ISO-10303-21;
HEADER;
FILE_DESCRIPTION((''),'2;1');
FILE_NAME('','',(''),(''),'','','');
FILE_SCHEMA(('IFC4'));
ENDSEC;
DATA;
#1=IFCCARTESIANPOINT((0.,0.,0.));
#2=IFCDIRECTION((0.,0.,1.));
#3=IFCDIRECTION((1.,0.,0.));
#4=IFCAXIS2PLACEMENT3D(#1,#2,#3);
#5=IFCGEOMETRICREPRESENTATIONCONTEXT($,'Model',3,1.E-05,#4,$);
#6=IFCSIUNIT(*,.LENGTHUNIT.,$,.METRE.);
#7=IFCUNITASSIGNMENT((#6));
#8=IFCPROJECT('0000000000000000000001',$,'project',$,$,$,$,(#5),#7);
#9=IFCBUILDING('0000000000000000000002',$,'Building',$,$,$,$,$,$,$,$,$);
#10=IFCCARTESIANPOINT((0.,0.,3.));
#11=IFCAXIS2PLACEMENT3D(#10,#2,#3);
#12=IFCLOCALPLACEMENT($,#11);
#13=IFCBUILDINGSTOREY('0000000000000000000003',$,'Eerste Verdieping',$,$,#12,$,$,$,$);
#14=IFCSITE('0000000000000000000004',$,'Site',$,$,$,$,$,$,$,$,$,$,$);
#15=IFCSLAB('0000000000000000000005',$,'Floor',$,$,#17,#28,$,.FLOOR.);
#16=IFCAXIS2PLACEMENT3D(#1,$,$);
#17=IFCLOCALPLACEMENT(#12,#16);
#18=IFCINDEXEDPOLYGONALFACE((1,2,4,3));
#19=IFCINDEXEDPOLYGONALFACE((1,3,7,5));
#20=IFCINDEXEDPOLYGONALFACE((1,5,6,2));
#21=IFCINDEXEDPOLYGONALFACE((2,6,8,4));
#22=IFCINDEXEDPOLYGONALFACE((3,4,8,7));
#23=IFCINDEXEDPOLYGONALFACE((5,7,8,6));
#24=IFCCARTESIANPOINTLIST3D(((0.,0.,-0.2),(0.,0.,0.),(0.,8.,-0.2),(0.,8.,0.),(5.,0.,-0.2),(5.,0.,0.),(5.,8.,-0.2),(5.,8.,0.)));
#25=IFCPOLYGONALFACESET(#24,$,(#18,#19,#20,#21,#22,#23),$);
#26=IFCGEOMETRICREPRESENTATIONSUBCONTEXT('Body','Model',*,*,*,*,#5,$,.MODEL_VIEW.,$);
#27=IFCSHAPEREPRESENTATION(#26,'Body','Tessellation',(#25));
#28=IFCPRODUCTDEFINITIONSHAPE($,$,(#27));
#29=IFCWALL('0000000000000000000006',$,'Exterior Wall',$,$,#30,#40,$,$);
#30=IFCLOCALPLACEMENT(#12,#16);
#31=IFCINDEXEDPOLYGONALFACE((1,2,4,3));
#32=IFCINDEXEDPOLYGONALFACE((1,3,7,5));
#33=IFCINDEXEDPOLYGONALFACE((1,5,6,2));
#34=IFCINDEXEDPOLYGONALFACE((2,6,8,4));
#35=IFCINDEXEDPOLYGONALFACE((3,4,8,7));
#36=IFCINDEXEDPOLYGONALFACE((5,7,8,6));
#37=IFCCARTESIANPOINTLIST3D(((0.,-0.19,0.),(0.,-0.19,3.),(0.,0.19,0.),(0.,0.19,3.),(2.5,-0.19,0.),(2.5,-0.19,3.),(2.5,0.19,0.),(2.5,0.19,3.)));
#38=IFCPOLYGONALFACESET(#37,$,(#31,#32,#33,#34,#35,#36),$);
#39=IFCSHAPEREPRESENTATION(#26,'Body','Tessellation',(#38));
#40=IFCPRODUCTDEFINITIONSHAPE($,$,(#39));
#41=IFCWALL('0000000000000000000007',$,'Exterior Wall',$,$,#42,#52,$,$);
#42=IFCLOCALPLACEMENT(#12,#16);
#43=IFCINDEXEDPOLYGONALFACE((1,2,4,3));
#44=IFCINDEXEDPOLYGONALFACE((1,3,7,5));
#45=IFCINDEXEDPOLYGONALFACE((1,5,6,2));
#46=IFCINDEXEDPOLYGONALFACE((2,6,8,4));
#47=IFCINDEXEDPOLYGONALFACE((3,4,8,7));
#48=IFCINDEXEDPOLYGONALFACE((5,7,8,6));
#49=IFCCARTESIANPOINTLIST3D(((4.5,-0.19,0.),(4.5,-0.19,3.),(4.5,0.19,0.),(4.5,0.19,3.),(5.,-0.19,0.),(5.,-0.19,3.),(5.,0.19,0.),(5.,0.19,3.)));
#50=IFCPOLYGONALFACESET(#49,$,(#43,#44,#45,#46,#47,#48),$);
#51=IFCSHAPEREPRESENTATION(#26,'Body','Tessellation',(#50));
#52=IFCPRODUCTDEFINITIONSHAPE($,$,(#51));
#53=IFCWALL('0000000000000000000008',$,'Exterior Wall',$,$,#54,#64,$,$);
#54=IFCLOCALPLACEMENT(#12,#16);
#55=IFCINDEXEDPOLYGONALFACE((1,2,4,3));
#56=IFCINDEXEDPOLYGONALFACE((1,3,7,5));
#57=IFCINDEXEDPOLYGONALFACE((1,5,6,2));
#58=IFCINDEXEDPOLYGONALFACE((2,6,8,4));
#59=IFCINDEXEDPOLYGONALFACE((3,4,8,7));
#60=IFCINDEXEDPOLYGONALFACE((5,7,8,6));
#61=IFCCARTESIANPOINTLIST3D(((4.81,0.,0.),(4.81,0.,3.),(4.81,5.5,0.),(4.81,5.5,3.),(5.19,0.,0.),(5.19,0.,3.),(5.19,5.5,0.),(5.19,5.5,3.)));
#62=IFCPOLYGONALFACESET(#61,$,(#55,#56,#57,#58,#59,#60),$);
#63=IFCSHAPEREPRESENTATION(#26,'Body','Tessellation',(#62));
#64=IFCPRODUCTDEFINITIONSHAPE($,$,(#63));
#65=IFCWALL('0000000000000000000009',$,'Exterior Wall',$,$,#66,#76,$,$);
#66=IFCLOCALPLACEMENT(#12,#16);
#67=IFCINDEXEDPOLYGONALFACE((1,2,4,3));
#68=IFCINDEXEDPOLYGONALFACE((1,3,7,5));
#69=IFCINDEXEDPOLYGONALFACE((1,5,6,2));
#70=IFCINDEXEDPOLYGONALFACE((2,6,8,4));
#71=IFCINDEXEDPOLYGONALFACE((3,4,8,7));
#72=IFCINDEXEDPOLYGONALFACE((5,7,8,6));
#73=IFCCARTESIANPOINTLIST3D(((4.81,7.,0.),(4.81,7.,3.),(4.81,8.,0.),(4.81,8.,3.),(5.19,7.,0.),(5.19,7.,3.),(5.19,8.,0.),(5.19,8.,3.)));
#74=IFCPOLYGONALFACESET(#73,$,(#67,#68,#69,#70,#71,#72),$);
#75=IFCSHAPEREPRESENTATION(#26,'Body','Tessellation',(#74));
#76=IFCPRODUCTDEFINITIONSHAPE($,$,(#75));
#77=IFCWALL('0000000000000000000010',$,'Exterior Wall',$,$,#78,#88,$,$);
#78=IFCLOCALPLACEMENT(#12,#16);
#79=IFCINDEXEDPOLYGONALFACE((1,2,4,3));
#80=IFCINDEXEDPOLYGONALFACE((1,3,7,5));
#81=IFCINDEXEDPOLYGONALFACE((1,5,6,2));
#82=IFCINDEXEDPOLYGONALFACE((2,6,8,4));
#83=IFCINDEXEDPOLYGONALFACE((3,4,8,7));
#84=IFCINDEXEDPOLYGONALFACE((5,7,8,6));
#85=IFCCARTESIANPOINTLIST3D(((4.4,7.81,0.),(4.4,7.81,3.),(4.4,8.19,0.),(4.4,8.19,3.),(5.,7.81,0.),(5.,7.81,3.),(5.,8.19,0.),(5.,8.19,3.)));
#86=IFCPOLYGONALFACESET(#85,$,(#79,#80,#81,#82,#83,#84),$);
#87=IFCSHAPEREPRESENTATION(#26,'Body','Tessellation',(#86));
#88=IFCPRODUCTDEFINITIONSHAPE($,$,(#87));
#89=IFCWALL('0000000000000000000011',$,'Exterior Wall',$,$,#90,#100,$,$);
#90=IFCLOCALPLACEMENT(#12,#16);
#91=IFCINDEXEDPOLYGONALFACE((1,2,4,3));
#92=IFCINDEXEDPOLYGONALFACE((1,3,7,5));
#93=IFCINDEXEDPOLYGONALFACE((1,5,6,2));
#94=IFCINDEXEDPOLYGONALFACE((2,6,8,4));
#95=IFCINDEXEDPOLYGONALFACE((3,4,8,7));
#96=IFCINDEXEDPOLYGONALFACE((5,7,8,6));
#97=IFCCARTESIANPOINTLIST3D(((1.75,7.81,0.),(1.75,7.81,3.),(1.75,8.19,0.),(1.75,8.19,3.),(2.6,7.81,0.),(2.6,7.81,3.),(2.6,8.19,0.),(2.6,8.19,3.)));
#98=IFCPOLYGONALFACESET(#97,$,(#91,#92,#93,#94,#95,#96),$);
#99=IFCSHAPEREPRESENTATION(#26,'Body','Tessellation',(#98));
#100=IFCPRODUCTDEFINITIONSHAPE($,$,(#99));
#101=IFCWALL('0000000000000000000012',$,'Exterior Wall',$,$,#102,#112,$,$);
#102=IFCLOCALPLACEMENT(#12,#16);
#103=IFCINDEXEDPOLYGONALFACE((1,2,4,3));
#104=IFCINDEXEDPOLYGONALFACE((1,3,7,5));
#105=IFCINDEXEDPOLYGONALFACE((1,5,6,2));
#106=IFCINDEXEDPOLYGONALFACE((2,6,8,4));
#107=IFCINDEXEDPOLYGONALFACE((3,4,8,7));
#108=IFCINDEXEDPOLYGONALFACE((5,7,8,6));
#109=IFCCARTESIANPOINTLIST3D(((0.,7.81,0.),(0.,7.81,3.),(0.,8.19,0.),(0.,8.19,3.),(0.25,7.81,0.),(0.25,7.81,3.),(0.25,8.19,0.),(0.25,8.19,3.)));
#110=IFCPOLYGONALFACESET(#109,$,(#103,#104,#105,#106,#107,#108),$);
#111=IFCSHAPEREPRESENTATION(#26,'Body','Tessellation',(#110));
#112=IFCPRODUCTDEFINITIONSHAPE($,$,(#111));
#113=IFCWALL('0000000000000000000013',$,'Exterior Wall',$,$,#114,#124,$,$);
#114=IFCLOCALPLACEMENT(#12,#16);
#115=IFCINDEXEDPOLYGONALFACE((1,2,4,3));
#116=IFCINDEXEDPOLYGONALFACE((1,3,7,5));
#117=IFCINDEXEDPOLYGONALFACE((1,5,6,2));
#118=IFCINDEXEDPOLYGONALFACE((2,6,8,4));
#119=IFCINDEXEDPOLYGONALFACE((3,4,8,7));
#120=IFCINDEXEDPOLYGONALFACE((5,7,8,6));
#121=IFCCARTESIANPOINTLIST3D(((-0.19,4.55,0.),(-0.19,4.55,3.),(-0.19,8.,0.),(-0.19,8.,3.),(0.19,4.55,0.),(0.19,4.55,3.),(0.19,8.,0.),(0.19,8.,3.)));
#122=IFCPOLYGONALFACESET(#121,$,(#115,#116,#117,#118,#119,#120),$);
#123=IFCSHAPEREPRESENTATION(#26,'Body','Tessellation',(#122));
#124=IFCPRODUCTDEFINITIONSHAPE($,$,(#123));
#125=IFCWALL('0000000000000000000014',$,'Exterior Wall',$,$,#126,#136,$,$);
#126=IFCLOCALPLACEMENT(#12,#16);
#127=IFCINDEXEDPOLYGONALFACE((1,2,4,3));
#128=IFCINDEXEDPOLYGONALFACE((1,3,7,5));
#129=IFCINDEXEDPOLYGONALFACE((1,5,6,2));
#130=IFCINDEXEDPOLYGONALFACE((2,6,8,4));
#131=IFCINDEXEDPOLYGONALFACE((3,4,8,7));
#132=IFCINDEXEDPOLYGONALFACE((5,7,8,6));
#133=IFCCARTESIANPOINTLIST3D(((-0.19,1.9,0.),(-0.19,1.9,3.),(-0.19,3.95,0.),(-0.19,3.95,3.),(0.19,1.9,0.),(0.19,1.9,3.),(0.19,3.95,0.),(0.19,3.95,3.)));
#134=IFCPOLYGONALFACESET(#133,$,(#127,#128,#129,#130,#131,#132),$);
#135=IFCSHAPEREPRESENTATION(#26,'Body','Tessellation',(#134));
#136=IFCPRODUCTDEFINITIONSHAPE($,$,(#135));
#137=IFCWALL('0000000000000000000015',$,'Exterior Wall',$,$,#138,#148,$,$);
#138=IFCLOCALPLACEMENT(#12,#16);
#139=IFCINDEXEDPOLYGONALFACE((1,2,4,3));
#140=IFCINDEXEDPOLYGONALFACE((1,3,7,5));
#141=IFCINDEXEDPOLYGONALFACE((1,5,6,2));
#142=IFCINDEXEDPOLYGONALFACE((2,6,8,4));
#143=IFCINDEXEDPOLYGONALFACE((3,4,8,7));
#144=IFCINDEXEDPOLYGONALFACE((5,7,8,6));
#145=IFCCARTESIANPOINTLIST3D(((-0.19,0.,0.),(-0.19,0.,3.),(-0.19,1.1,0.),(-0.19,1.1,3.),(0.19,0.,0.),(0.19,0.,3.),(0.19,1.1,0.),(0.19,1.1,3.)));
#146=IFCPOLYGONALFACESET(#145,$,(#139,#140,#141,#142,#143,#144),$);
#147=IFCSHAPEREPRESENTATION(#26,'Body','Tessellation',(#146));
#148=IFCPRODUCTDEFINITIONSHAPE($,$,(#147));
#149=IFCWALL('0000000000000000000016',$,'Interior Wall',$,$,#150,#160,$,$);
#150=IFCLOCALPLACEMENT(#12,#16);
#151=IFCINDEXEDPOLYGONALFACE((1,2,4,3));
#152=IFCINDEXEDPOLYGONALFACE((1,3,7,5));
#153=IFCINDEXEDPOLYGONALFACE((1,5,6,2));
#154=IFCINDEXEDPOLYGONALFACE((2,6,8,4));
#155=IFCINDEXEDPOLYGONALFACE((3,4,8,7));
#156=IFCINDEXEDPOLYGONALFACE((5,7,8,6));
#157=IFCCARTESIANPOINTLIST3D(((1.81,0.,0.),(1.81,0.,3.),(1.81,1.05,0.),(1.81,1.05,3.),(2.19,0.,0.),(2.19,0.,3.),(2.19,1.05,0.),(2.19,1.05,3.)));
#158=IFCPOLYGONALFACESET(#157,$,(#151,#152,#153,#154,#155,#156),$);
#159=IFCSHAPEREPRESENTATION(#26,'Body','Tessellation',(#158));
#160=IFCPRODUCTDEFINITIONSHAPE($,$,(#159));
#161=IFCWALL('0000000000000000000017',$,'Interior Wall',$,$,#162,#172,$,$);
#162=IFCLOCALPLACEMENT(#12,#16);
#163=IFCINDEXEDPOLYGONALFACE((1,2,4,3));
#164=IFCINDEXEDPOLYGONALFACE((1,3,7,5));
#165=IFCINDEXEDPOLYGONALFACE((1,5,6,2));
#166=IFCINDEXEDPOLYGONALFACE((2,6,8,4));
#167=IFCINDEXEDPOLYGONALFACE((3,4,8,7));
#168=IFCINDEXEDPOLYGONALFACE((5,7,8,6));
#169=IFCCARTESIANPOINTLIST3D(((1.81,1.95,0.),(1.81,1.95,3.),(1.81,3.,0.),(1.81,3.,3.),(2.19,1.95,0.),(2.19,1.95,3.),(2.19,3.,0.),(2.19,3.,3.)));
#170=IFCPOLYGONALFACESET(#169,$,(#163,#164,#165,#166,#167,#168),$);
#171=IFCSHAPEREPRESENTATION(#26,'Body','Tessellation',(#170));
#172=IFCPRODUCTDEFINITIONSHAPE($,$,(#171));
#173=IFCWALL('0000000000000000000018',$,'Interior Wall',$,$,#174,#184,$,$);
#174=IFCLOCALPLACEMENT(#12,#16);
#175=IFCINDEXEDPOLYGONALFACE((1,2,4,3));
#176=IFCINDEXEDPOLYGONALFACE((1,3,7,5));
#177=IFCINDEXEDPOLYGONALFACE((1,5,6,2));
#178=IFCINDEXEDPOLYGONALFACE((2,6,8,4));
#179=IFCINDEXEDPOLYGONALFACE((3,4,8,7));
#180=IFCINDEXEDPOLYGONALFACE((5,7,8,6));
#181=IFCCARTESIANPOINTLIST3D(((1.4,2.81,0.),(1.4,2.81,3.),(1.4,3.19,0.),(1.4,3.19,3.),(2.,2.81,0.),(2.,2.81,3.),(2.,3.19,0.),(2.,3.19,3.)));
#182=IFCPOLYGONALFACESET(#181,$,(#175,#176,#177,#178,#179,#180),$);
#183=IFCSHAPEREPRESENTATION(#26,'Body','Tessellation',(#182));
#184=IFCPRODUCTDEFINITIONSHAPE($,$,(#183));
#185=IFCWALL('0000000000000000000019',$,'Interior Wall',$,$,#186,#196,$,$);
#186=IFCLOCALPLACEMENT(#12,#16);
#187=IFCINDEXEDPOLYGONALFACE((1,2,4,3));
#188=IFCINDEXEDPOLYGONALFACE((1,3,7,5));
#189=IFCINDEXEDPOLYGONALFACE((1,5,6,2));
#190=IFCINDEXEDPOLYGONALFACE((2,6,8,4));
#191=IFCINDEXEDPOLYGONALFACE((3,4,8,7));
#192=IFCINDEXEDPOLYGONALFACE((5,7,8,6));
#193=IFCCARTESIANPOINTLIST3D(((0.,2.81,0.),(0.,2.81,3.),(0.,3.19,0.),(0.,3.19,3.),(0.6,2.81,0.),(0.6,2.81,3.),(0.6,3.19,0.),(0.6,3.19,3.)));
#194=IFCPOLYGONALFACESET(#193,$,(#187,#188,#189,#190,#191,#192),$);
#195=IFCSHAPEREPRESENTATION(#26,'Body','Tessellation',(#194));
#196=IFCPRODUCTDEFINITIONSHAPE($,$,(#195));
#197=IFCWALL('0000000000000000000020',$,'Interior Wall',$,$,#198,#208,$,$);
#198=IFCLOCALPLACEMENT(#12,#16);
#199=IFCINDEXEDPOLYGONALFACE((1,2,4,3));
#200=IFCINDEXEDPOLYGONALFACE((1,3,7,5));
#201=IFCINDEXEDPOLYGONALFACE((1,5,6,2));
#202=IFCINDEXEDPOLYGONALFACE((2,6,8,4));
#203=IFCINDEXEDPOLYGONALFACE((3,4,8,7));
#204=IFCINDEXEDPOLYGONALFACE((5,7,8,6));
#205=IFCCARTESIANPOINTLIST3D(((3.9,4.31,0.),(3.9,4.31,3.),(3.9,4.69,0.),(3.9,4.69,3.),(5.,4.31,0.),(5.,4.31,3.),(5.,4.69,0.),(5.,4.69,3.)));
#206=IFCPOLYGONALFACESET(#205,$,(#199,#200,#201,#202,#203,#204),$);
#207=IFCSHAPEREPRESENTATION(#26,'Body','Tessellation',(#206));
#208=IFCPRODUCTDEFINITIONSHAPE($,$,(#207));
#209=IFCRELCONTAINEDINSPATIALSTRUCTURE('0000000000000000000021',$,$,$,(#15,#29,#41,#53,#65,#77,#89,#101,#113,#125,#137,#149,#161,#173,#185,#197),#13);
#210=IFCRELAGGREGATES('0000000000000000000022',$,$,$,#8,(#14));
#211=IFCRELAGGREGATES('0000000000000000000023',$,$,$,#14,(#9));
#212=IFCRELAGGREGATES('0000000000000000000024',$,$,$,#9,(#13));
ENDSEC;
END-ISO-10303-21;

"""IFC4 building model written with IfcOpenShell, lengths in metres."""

from ifc_helpers import new_model, si_unit, frame, origin_with_axes, place, context, subcontext, project, spatial, indexed_curve, outline, extrude, element, save


model = new_model("IFC4")

# Units and contexts
model_context = context("Model", 3, precision=1e-05, world=origin_with_axes())
body_context = subcontext(model_context, "Body", "Model", "MODEL_VIEW")
ifc_project = project(units=[si_unit("LENGTHUNIT", "METRE")], contexts=[model_context])

# Site, building, storey
site = spatial("IfcSite", under=ifc_project, Name="Site")
building = spatial("IfcBuilding", under=site, Name="Building")
storey_placement = place(None, frame((0.0, 0.0, 3.0), z_axis=(0.0, 0.0, 1.0), x_axis=(1.0, 0.0, 0.0)))
storey = spatial("IfcBuildingStorey", under=building, at=storey_placement, Name="Eerste Verdieping")

# Slab
slab_placement = place(storey_placement, frame((0.0, 0.0, -0.2), z_axis=(0.0, 0.0, 1.0), x_axis=(1.0, 0.0, 0.0)))
element("IfcSlab", 1, at=slab_placement, inside=storey, Name="Floor", PredefinedType="FLOOR", context=body_context, shape_type="SweptSolid", body=[
    extrude(outline(indexed_curve([(0.0, 0.0), (5.0, 0.0), (5.0, 8.0), (0.0, 8.0)])), None, (0.0, 0.0, 1.0), 0.2),
])

# Walls
wall_1_placement = place(storey_placement, origin_with_axes())
element("IfcWall", 2, at=wall_1_placement, inside=storey, Name="Exterior Wall", context=body_context, shape_type="SweptSolid", body=[
    extrude(outline(indexed_curve([(0.0, 0.0), (0.0, 0.38), (2.5, 0.38), (2.5, 0.0), (0.0, 0.0)], self_intersect=False)), frame((0.0, -0.19, 0.0), z_axis=(0.0, 0.0, 1.0), x_axis=(1.0, 0.0, 0.0)), (0.0, 0.0, 1.0), 3.0),
])
wall_2_placement = place(storey_placement, frame((4.5, 0.0, 0.0), z_axis=(0.0, 0.0, 1.0), x_axis=(1.0, 0.0, 0.0)))
element("IfcWall", 3, at=wall_2_placement, inside=storey, Name="Exterior Wall", context=body_context, shape_type="SweptSolid", body=[
    extrude(outline(indexed_curve([(0.0, 0.0), (0.0, 0.38), (0.5, 0.38), (0.5, 0.0), (0.0, 0.0)], self_intersect=False)), frame((0.0, -0.19, 0.0), z_axis=(0.0, 0.0, 1.0), x_axis=(1.0, 0.0, 0.0)), (0.0, 0.0, 1.0), 3.0),
])
wall_3_placement = place(storey_placement, frame((5.0, 0.0, 0.0), z_axis=(0.0, 0.0, 1.0), x_axis=(0.0, 1.0, 0.0)))
element("IfcWall", 4, at=wall_3_placement, inside=storey, Name="Exterior Wall", context=body_context, shape_type="SweptSolid", body=[
    extrude(outline(indexed_curve([(0.0, 0.0), (0.0, 0.38), (5.5, 0.38), (5.5, 0.0), (0.0, 0.0)], self_intersect=False)), frame((0.0, -0.19, 0.0), z_axis=(0.0, 0.0, 1.0), x_axis=(1.0, 0.0, 0.0)), (0.0, 0.0, 1.0), 3.0),
])
wall_4_placement = place(storey_placement, frame((5.0, 7.0, 0.0), z_axis=(0.0, 0.0, 1.0), x_axis=(0.0, 1.0, 0.0)))
element("IfcWall", 5, at=wall_4_placement, inside=storey, Name="Exterior Wall", context=body_context, shape_type="SweptSolid", body=[
    extrude(outline(indexed_curve([(0.0, 0.0), (0.0, 0.38), (1.0, 0.38), (1.0, 0.0), (0.0, 0.0)], self_intersect=False)), frame((0.0, -0.19, 0.0), z_axis=(0.0, 0.0, 1.0), x_axis=(1.0, 0.0, 0.0)), (0.0, 0.0, 1.0), 3.0),
])
wall_5_placement = place(storey_placement, frame((5.0, 8.0, 0.0), z_axis=(0.0, 0.0, 1.0), x_axis=(-1.0, 0.0, 0.0)))
element("IfcWall", 6, at=wall_5_placement, inside=storey, Name="Exterior Wall", context=body_context, shape_type="SweptSolid", body=[
    extrude(outline(indexed_curve([(0.0, 0.0), (0.0, 0.38), (0.6, 0.38), (0.6, 0.0), (0.0, 0.0)], self_intersect=False)), frame((0.0, -0.19, 0.0), z_axis=(0.0, 0.0, 1.0), x_axis=(1.0, 0.0, 0.0)), (0.0, 0.0, 1.0), 3.0),
])
wall_6_placement = place(storey_placement, frame((2.6, 8.0, 0.0), z_axis=(0.0, 0.0, 1.0), x_axis=(-1.0, 0.0, 0.0)))
element("IfcWall", 7, at=wall_6_placement, inside=storey, Name="Exterior Wall", context=body_context, shape_type="SweptSolid", body=[
    extrude(outline(indexed_curve([(0.0, 0.0), (0.0, 0.38), (0.85, 0.38), (0.85, 0.0), (0.0, 0.0)], self_intersect=False)), frame((0.0, -0.19, 0.0), z_axis=(0.0, 0.0, 1.0), x_axis=(1.0, 0.0, 0.0)), (0.0, 0.0, 1.0), 3.0),
])
wall_7_placement = place(storey_placement, frame((0.25, 8.0, 0.0), z_axis=(0.0, 0.0, 1.0), x_axis=(-1.0, 0.0, 0.0)))
element("IfcWall", 8, at=wall_7_placement, inside=storey, Name="Exterior Wall", context=body_context, shape_type="SweptSolid", body=[
    extrude(outline(indexed_curve([(0.0, 0.0), (0.0, 0.38), (0.25, 0.38), (0.25, 0.0), (0.0, 0.0)], self_intersect=False)), frame((0.0, -0.19, 0.0), z_axis=(0.0, 0.0, 1.0), x_axis=(1.0, 0.0, 0.0)), (0.0, 0.0, 1.0), 3.0),
])
wall_8_placement = place(storey_placement, frame((0.0, 8.0, 0.0), z_axis=(0.0, 0.0, 1.0), x_axis=(0.0, -1.0, 0.0)))
element("IfcWall", 9, at=wall_8_placement, inside=storey, Name="Exterior Wall", context=body_context, shape_type="SweptSolid", body=[
    extrude(outline(indexed_curve([(0.0, 0.0), (0.0, 0.38), (3.45, 0.38), (3.45, 0.0), (0.0, 0.0)], self_intersect=False)), frame((0.0, -0.19, 0.0), z_axis=(0.0, 0.0, 1.0), x_axis=(1.0, 0.0, 0.0)), (0.0, 0.0, 1.0), 3.0),
])
wall_9_placement = place(storey_placement, frame((0.0, 3.95, 0.0), z_axis=(0.0, 0.0, 1.0), x_axis=(0.0, -1.0, 0.0)))
element("IfcWall", 10, at=wall_9_placement, inside=storey, Name="Exterior Wall", context=body_context, shape_type="SweptSolid", body=[
    extrude(outline(indexed_curve([(0.0, 0.0), (0.0, 0.38), (2.05, 0.38), (2.05, 0.0), (0.0, 0.0)], self_intersect=False)), frame((0.0, -0.19, 0.0), z_axis=(0.0, 0.0, 1.0), x_axis=(1.0, 0.0, 0.0)), (0.0, 0.0, 1.0), 3.0),
])
wall_10_placement = place(storey_placement, frame((0.0, 1.1, 0.0), z_axis=(0.0, 0.0, 1.0), x_axis=(0.0, -1.0, 0.0)))
element("IfcWall", 11, at=wall_10_placement, inside=storey, Name="Exterior Wall", context=body_context, shape_type="SweptSolid", body=[
    extrude(outline(indexed_curve([(0.0, 0.0), (0.0, 0.38), (1.1, 0.38), (1.1, 0.0), (0.0, 0.0)], self_intersect=False)), frame((0.0, -0.19, 0.0), z_axis=(0.0, 0.0, 1.0), x_axis=(1.0, 0.0, 0.0)), (0.0, 0.0, 1.0), 3.0),
])
for number, where, z_axis, x_axis, name in (
    (12, (2.0, 0.0, 0.0), (0.0, 0.0, 1.0), (0.0, 1.0, 0.0), "Interior Wall"),
    (13, (2.0, 1.95, 0.0), (0.0, 0.0, 1.0), (0.0, 1.0, 0.0), "Interior Wall"),
):
    element("IfcWall", number, at=place(storey_placement, frame(where, z_axis=z_axis, x_axis=x_axis)), inside=storey, Name=name, context=body_context, shape_type="SweptSolid", body=[
        extrude(outline(indexed_curve([(0.0, 0.0), (0.0, 0.38), (1.05, 0.38), (1.05, 0.0), (0.0, 0.0)], self_intersect=False)), frame((0.0, -0.19, 0.0), z_axis=(0.0, 0.0, 1.0), x_axis=(1.0, 0.0, 0.0)), (0.0, 0.0, 1.0), 3.0),
    ])
for number, where, z_axis, x_axis, name in (
    (14, (2.0, 3.0, 0.0), (0.0, 0.0, 1.0), (-1.0, 0.0, 0.0), "Interior Wall"),
    (15, (0.6, 3.0, 0.0), (0.0, 0.0, 1.0), (-1.0, 0.0, 0.0), "Interior Wall"),
):
    element("IfcWall", number, at=place(storey_placement, frame(where, z_axis=z_axis, x_axis=x_axis)), inside=storey, Name=name, context=body_context, shape_type="SweptSolid", body=[
        extrude(outline(indexed_curve([(0.0, 0.0), (0.0, 0.38), (0.6, 0.38), (0.6, 0.0), (0.0, 0.0)], self_intersect=False)), frame((0.0, -0.19, 0.0), z_axis=(0.0, 0.0, 1.0), x_axis=(1.0, 0.0, 0.0)), (0.0, 0.0, 1.0), 3.0),
    ])
for number, where, z_axis, x_axis, name in (
    (16, (5.0, 4.5, 0.0), (0.0, 0.0, 1.0), (-1.0, 0.0, 0.0), "Interior Wall"),
):
    element("IfcWall", number, at=place(storey_placement, frame(where, z_axis=z_axis, x_axis=x_axis)), inside=storey, Name=name, context=body_context, shape_type="SweptSolid", body=[
        extrude(outline(indexed_curve([(0.0, 0.0), (0.0, 0.38), (1.1, 0.38), (1.1, 0.0), (0.0, 0.0)], self_intersect=False)), frame((0.0, -0.19, 0.0), z_axis=(0.0, 0.0, 1.0), x_axis=(1.0, 0.0, 0.0)), (0.0, 0.0, 1.0), 3.0),
    ])

save(model, "model.ifc")
